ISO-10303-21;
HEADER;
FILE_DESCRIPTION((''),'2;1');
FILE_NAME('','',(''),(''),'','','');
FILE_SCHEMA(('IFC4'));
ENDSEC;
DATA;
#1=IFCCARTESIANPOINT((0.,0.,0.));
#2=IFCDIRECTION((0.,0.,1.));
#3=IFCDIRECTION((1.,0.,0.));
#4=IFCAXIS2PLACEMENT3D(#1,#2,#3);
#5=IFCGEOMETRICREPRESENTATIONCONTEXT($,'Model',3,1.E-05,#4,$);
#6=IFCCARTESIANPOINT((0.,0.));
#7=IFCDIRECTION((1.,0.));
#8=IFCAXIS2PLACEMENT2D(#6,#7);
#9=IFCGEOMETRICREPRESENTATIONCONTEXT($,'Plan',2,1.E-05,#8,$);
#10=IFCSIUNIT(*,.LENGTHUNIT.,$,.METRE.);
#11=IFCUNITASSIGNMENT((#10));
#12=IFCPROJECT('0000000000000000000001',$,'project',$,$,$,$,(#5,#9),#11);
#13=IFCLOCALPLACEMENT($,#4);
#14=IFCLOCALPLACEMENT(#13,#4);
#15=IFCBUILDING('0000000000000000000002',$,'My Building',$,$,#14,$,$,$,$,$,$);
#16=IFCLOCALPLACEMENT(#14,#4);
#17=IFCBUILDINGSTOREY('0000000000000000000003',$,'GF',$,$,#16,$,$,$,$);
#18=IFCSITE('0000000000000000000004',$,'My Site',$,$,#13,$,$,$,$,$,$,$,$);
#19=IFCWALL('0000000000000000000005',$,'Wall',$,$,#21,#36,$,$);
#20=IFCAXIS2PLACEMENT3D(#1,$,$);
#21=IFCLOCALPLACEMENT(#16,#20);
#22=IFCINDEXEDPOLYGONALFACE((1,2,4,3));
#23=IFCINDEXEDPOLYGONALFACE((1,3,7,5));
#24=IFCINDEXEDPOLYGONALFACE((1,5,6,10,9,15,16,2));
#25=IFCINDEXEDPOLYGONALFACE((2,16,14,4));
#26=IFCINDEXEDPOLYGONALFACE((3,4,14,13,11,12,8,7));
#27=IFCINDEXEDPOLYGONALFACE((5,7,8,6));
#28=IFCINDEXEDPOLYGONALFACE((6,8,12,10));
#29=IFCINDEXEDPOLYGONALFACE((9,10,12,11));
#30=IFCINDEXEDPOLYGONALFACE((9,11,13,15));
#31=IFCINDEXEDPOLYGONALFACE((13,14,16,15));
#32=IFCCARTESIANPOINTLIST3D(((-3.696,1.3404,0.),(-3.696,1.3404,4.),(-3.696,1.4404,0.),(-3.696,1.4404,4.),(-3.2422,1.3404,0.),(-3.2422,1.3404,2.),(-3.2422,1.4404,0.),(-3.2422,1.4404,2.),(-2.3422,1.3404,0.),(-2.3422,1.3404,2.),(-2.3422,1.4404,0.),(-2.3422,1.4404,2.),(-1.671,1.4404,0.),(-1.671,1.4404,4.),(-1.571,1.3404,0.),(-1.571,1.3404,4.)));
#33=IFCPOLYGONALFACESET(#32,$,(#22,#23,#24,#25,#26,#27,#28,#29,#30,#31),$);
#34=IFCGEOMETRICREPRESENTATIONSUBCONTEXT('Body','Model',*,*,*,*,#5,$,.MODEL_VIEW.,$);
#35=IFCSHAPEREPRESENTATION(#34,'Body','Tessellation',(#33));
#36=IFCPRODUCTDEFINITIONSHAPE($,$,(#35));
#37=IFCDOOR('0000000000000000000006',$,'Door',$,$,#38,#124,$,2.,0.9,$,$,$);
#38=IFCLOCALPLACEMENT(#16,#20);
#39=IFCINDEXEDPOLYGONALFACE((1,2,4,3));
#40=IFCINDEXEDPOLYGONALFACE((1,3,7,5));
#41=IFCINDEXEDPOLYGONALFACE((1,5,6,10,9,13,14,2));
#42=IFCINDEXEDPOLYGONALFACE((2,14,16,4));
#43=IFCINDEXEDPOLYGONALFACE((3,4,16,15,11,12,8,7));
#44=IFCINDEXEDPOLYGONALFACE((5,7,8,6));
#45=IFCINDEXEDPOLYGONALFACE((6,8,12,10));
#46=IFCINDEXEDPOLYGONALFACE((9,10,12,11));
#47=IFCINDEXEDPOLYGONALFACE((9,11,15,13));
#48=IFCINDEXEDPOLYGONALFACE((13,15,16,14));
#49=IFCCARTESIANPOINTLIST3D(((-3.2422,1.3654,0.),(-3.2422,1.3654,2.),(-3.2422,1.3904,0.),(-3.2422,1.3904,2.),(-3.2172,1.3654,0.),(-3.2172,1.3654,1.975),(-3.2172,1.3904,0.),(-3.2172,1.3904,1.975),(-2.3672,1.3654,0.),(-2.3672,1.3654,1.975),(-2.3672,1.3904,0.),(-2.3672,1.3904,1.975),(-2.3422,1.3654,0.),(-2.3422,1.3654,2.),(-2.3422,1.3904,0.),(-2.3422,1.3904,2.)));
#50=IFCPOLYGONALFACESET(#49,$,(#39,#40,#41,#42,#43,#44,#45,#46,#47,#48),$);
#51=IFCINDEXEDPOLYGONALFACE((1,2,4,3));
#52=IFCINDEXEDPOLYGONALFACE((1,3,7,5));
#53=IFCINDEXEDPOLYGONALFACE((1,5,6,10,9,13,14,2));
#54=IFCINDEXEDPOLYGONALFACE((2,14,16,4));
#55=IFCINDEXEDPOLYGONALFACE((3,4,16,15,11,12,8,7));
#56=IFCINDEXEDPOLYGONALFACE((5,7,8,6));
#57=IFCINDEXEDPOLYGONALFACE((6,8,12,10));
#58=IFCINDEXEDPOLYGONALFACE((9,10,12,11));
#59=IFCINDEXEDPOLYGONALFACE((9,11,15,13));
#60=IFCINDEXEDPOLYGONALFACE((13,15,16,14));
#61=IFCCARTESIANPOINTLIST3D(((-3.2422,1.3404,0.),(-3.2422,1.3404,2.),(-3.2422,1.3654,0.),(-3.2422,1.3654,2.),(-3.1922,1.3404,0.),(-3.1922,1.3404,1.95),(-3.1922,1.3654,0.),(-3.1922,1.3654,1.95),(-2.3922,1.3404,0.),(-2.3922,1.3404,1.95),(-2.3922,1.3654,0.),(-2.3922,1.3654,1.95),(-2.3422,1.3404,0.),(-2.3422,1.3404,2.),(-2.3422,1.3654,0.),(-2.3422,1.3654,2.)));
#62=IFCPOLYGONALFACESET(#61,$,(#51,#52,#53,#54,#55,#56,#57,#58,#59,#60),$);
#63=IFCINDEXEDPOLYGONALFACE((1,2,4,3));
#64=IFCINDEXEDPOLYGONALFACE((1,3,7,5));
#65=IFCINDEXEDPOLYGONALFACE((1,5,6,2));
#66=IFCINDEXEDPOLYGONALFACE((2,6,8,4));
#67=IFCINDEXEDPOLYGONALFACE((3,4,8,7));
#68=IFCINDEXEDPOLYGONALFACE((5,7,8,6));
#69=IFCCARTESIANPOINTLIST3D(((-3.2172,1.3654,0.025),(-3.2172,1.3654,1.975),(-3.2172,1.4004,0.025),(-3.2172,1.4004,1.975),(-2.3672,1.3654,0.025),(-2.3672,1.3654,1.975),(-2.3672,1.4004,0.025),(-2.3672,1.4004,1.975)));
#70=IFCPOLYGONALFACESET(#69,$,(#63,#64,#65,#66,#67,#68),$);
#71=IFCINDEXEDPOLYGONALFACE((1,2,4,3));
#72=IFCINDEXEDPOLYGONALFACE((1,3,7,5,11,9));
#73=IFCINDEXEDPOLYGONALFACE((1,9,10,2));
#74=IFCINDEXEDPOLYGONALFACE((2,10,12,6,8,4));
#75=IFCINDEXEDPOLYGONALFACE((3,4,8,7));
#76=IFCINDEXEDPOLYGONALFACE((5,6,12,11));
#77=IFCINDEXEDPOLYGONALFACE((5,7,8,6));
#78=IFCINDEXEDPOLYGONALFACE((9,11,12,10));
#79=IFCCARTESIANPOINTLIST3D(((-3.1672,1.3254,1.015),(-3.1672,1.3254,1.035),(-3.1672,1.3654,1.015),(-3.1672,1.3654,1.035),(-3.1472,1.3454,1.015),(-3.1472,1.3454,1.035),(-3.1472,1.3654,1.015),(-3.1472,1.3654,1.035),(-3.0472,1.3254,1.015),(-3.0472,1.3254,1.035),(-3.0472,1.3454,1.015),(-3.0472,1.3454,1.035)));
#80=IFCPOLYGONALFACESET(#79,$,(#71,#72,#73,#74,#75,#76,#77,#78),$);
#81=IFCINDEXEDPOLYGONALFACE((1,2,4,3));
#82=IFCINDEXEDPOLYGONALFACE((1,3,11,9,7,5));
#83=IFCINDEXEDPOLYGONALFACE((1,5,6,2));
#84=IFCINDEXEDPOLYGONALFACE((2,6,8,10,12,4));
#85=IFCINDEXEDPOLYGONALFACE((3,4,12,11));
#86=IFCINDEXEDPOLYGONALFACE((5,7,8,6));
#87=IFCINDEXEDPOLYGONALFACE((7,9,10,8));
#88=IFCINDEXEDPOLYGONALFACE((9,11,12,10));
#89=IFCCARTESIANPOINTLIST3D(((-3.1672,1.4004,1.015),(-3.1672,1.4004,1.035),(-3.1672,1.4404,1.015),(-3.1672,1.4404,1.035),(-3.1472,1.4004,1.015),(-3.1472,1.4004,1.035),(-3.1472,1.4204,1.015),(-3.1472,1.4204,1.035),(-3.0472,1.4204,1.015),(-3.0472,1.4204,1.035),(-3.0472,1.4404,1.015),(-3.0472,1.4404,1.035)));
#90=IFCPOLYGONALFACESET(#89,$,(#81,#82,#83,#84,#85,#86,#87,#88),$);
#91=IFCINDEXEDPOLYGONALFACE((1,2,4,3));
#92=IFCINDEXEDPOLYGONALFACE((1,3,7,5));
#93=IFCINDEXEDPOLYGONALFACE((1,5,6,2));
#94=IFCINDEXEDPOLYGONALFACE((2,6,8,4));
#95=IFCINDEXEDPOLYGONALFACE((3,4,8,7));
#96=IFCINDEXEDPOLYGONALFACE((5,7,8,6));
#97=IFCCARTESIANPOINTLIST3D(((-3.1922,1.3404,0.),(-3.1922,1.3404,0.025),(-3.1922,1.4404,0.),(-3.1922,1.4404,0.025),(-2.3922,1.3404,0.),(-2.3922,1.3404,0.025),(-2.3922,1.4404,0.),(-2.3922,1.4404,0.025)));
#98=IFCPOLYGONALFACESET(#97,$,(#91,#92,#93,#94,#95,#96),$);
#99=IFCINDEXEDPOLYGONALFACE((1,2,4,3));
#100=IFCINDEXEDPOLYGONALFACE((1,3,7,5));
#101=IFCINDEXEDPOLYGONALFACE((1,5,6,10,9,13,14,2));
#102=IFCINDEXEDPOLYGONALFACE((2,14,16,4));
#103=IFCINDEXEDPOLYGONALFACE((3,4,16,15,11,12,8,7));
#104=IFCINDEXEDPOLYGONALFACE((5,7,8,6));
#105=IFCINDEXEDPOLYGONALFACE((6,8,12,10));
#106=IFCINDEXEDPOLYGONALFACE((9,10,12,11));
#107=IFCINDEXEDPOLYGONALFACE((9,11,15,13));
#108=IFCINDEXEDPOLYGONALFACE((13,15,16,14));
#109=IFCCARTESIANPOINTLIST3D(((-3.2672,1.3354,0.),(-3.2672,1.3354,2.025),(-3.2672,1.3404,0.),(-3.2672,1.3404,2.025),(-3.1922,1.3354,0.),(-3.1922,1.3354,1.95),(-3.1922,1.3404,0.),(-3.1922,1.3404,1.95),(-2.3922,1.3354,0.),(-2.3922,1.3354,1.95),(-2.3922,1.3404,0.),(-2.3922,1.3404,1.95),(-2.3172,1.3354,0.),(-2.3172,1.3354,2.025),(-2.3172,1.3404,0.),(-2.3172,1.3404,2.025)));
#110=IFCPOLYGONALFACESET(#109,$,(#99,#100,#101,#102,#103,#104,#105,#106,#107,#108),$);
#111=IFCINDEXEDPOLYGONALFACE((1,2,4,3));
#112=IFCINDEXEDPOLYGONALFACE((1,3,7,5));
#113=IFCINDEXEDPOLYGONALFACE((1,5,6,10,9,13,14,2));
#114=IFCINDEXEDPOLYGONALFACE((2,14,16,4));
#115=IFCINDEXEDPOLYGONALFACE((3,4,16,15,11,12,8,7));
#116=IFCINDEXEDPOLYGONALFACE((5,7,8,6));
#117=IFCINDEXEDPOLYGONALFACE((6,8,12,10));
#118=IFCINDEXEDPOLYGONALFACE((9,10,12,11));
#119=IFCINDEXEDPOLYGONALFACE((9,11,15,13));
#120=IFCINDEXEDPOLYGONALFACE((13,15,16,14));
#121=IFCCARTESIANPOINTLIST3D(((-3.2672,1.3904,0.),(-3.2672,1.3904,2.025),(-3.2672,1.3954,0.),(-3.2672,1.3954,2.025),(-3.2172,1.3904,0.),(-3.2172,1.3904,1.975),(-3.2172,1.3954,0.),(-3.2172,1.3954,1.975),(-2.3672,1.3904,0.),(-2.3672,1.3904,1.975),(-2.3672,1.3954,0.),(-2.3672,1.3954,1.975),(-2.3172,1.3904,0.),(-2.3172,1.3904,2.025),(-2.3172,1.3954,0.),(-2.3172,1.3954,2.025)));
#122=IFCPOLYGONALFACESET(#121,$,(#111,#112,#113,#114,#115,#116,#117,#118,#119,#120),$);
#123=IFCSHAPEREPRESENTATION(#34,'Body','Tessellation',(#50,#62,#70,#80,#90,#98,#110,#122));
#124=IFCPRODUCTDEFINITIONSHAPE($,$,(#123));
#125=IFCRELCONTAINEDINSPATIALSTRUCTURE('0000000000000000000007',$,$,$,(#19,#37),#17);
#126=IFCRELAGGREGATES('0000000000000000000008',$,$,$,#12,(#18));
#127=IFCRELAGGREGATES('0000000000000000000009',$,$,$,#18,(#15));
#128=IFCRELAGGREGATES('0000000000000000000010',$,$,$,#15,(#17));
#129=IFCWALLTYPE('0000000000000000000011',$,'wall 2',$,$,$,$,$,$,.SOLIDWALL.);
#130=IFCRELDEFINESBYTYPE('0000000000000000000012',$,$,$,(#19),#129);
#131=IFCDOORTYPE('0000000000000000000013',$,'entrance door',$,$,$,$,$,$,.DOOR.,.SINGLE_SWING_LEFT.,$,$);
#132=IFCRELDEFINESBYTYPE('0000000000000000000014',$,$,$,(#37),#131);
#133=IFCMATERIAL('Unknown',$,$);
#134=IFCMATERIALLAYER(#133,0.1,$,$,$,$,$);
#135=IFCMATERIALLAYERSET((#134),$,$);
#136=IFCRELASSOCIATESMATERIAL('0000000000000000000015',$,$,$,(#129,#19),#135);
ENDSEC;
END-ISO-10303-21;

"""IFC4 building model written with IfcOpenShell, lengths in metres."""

from ifc_helpers import new_model, entity, si_unit, frame, origin_with_axes, origin_2d_with_axis, place, context, subcontext, project, spatial, line, indexed_curve, outline, extrude, shape, source, transform, mapped, material, layer, layer_set, layer_usage, type_object, type_shapes, element, fill, save


model = new_model("IFC4")

# Units and contexts
model_context = context("Model", 3, precision=1e-05, world=origin_with_axes())
plan_context = context("Plan", 2, precision=1e-05, world=origin_2d_with_axis())
body_context_1 = subcontext(model_context, "Body", "Model", "MODEL_VIEW")
body_context_2 = subcontext(plan_context, "Body", "Plan", "PLAN_VIEW")
ifc_project = project(units=[si_unit("LENGTHUNIT", "METRE")], contexts=[model_context, plan_context])

# Site, building, storey
site_placement = place(None, origin_with_axes())
site = spatial("IfcSite", under=ifc_project, at=site_placement, Name="My Site")
building_placement = place(site_placement, origin_with_axes())
building = spatial("IfcBuilding", under=site, at=building_placement, Name="My Building")
storey_placement = place(building_placement, origin_with_axes())
storey = spatial("IfcBuildingStorey", under=building, at=storey_placement, Name="GF")

# Shared definitions
ifc_material = material(Name="Unknown")

# Shared definitions
shared_shape_1 = source(origin_with_axes(), body_context_1, "Body", "SweptSolid", [
    extrude(outline(indexed_curve([(0.0, 0.0), (0.9, 0.0), (0.9, 2.0), (0.0, 2.0)], segments=[line(1, 2, 3, 4, 1)])), frame((0.0, -0.6, 0.0), z_axis=(0.0, -1.0, 0.0), x_axis=(1.0, 0.0, 0.0)), (0.0, 0.0, -1.0), 1.2),
])
door_type = type_object("IfcDoorType", Name="entrance door", OperationType="SINGLE_SWING_LEFT", PredefinedType="DOOR")
shared_shape_2 = source(origin_with_axes(), body_context_1, "Body", "SweptSolid", [
    extrude(outline(indexed_curve([(0.0, 0.0), (0.0, 2.0), (0.9, 2.0), (0.9, 0.0), (0.875, 0.0), (0.875, 1.975), (0.025, 1.975), (0.025, 0.0)], segments=[line(1, 2, 3, 4, 5, 6, 7, 8, 1)])), frame((0.0, 0.025, 0.0), z_axis=(0.0, -1.0, 0.0), x_axis=(1.0, 0.0, 0.0)), (0.0, 0.0, -1.0), 0.025),
    extrude(outline(indexed_curve([(0.0, 0.0), (0.0, 2.0), (0.9, 2.0), (0.9, 0.0), (0.85, 0.0), (0.85, 1.95), (0.05, 1.95), (0.05, 0.0)], segments=[line(1, 2, 3, 4, 5, 6, 7, 8, 1)])), frame((0.0, 0.0, 0.0), z_axis=(0.0, -1.0, 0.0), x_axis=(1.0, 0.0, 0.0)), (0.0, 0.0, -1.0), 0.025),
    extrude(outline(indexed_curve([(0.0, 0.0), (0.85, 0.0), (0.85, 0.035), (0.0, 0.035)], segments=[line(1, 2, 3, 4, 1)])), frame((0.025, 0.025, 0.025), z_axis=(0.0, 0.0, 1.0), x_axis=(1.0, 0.0, 0.0)), (0.0, 0.0, 1.0), 1.95),
    extrude(outline(indexed_curve([(0.0, 0.0), (0.0, -0.04), (0.12, -0.04), (0.12, -0.02), (0.02, -0.02), (0.02, 0.0)], segments=[line(1, 2, 3, 4, 5, 6, 1)])), frame((0.075, 0.025, 1.015), z_axis=(0.0, 0.0, 1.0), x_axis=(1.0, 0.0, 0.0)), (0.0, 0.0, 1.0), 0.02),
    extrude(outline(indexed_curve([(0.0, 0.0), (0.0, 0.04), (0.12, 0.04), (0.12, 0.02), (0.02, 0.02), (0.02, 0.0)], segments=[line(1, 2, 3, 4, 5, 6, 1)])), frame((0.075, 0.06, 1.015), z_axis=(0.0, 0.0, 1.0), x_axis=(1.0, 0.0, 0.0)), (0.0, 0.0, 1.0), 0.02),
    extrude(outline(indexed_curve([(0.0, 0.0), (0.8, 0.0), (0.8, 0.1), (0.0, 0.1)], segments=[line(1, 2, 3, 4, 1)])), frame((0.05, 0.0, 0.0), z_axis=(0.0, 0.0, 1.0), x_axis=(1.0, 0.0, 0.0)), (0.0, 0.0, 1.0), 0.025),
    extrude(outline(indexed_curve([(0.0, 0.0), (0.0, 2.025), (0.95, 2.025), (0.95, 0.0), (0.875, 0.0), (0.875, 1.95), (0.075, 1.95), (0.075, 0.0)], segments=[line(1, 2, 3, 4, 5, 6, 7, 8, 1)])), frame((-0.025, -0.005, 0.0), z_axis=(0.0, -1.0, 0.0), x_axis=(1.0, 0.0, 0.0)), (0.0, 0.0, -1.0), 0.005),
    extrude(outline(indexed_curve([(0.0, 0.0), (0.0, 2.025), (0.95, 2.025), (0.95, 0.0), (0.9, 0.0), (0.9, 1.975), (0.05, 1.975), (0.05, 0.0)], segments=[line(1, 2, 3, 4, 5, 6, 7, 8, 1)])), frame((-0.025, 0.05, 0.0), z_axis=(0.0, -1.0, 0.0), x_axis=(1.0, 0.0, 0.0)), (0.0, 0.0, -1.0), 0.005),
])
shared_shape_3 = source(origin_with_axes(), body_context_2, "Body", "Curve2D", [
    entity("IfcIndexedPolyCurve", entity("IfcCartesianPointList2D", [[0.0, 0.0], [0.0, 0.05], [0.025, 0.05], [0.025, 0.025], [0.05, 0.025], [0.05, 0.0]]), [entity("IfcLineIndex", [1, 2, 3, 4, 5, 6, 1])]),
    entity("IfcIndexedPolyCurve", entity("IfcCartesianPointList2D", [[0.9, 0.0], [0.9, 0.05], [0.875, 0.05], [0.875, 0.025], [0.85, 0.025], [0.85, 0.0]]), [entity("IfcLineIndex", [1, 2, 3, 4, 5, 6, 1])]),
    entity("IfcTrimmedCurve", entity("IfcEllipse", entity("IfcAxis2Placement2D", entity("IfcCartesianPoint", [0.84, 0.05]), entity("IfcDirection", [1.0, 0.0])), 0.815, 0.85), [entity("IfcCartesianPoint", [0.84, 0.9])], [entity("IfcCartesianPoint", [0.025, 0.05])], True, "CARTESIAN"),
    entity("IfcIndexedPolyCurve", entity("IfcCartesianPointList2D", [[0.875, 0.05], [0.84, 0.05], [0.84, 0.9], [0.875, 0.9]]), [entity("IfcLineIndex", [1, 2, 3, 4, 1])]),
])
type_shapes(door_type, [shared_shape_2, shared_shape_3])

# Shared definitions
ifc_layer_1 = layer(ifc_material, 0.1)
ifc_layer_set_1 = layer_set([ifc_layer_1])
wall_type_1 = type_object("IfcWallType", Name="wall 2", PredefinedType="SOLIDWALL", material=ifc_layer_set_1)

# Wall, opening, door
ifc_layer_usage_1 = layer_usage(ifc_layer_set_1, "AXIS2", "POSITIVE", 0.0)
wall_1_placement = place(storey_placement, frame((-1.671, 1.4404, 0.0), z_axis=(0.0, 0.0, 1.0), x_axis=(-1.0, 0.0, 0.0)))
wall_1 = element("IfcWall", 1, at=wall_1_placement, inside=storey, type_object=wall_type_1, material=ifc_layer_usage_1, Name="Wall", context=body_context_1, shape_type="SweptSolid", body=[
    extrude(outline(indexed_curve([(0.0, 0.0), (-0.1, 0.1), (2.025, 0.1), (2.025, 0.0)], segments=[line(1, 2, 3, 4, 1)])), origin_with_axes(), (0.0, 0.0, 1.0), 4.0),
])
opening_1_placement = place(wall_1_placement, frame((1.5713, 0.1, 0.0), z_axis=(0.0, 0.0, 1.0), x_axis=(-1.0, 0.0, 0.0)))
opening_1 = element("IfcOpeningElement", 2, at=opening_1_placement, cuts=wall_1, PredefinedType="OPENING", context=body_context_1, shape_type="MappedRepresentation", body=[
    mapped(shared_shape_1, transform((0.0, 0.0, 0.0), x_axis=(1.0, 0.0, 0.0), y_axis=(0.0, 1.0, 0.0), z_axis=(0.0, 0.0, 1.0), scale=1.0)),
])
door_1_placement = place(opening_1_placement, frame((0.0, 0.0, 0.0), z_axis=(0.0, 0.0, 1.0), x_axis=(1.0, 0.0, 0.0)))
door_1 = element("IfcDoor", 3, at=door_1_placement, inside=storey, type_object=door_type, Name="Door", OverallHeight=2.0, OverallWidth=0.9, shapes=[
    shape(body_context_1, "Body", "MappedRepresentation", [mapped(shared_shape_2, transform((0.0, 0.0, 0.0), x_axis=(1.0, 0.0, 0.0), y_axis=(0.0, 1.0, 0.0), z_axis=(0.0, 0.0, 1.0), scale=1.0))]),
    shape(body_context_2, "Body", "MappedRepresentation", [mapped(shared_shape_3, transform((0.0, 0.0, 0.0), x_axis=(1.0, 0.0, 0.0), y_axis=(0.0, 1.0, 0.0), z_axis=(0.0, 0.0, 1.0), scale=1.0))]),
])
fill(opening_1, door_1)

save(model, "model.ifc")
